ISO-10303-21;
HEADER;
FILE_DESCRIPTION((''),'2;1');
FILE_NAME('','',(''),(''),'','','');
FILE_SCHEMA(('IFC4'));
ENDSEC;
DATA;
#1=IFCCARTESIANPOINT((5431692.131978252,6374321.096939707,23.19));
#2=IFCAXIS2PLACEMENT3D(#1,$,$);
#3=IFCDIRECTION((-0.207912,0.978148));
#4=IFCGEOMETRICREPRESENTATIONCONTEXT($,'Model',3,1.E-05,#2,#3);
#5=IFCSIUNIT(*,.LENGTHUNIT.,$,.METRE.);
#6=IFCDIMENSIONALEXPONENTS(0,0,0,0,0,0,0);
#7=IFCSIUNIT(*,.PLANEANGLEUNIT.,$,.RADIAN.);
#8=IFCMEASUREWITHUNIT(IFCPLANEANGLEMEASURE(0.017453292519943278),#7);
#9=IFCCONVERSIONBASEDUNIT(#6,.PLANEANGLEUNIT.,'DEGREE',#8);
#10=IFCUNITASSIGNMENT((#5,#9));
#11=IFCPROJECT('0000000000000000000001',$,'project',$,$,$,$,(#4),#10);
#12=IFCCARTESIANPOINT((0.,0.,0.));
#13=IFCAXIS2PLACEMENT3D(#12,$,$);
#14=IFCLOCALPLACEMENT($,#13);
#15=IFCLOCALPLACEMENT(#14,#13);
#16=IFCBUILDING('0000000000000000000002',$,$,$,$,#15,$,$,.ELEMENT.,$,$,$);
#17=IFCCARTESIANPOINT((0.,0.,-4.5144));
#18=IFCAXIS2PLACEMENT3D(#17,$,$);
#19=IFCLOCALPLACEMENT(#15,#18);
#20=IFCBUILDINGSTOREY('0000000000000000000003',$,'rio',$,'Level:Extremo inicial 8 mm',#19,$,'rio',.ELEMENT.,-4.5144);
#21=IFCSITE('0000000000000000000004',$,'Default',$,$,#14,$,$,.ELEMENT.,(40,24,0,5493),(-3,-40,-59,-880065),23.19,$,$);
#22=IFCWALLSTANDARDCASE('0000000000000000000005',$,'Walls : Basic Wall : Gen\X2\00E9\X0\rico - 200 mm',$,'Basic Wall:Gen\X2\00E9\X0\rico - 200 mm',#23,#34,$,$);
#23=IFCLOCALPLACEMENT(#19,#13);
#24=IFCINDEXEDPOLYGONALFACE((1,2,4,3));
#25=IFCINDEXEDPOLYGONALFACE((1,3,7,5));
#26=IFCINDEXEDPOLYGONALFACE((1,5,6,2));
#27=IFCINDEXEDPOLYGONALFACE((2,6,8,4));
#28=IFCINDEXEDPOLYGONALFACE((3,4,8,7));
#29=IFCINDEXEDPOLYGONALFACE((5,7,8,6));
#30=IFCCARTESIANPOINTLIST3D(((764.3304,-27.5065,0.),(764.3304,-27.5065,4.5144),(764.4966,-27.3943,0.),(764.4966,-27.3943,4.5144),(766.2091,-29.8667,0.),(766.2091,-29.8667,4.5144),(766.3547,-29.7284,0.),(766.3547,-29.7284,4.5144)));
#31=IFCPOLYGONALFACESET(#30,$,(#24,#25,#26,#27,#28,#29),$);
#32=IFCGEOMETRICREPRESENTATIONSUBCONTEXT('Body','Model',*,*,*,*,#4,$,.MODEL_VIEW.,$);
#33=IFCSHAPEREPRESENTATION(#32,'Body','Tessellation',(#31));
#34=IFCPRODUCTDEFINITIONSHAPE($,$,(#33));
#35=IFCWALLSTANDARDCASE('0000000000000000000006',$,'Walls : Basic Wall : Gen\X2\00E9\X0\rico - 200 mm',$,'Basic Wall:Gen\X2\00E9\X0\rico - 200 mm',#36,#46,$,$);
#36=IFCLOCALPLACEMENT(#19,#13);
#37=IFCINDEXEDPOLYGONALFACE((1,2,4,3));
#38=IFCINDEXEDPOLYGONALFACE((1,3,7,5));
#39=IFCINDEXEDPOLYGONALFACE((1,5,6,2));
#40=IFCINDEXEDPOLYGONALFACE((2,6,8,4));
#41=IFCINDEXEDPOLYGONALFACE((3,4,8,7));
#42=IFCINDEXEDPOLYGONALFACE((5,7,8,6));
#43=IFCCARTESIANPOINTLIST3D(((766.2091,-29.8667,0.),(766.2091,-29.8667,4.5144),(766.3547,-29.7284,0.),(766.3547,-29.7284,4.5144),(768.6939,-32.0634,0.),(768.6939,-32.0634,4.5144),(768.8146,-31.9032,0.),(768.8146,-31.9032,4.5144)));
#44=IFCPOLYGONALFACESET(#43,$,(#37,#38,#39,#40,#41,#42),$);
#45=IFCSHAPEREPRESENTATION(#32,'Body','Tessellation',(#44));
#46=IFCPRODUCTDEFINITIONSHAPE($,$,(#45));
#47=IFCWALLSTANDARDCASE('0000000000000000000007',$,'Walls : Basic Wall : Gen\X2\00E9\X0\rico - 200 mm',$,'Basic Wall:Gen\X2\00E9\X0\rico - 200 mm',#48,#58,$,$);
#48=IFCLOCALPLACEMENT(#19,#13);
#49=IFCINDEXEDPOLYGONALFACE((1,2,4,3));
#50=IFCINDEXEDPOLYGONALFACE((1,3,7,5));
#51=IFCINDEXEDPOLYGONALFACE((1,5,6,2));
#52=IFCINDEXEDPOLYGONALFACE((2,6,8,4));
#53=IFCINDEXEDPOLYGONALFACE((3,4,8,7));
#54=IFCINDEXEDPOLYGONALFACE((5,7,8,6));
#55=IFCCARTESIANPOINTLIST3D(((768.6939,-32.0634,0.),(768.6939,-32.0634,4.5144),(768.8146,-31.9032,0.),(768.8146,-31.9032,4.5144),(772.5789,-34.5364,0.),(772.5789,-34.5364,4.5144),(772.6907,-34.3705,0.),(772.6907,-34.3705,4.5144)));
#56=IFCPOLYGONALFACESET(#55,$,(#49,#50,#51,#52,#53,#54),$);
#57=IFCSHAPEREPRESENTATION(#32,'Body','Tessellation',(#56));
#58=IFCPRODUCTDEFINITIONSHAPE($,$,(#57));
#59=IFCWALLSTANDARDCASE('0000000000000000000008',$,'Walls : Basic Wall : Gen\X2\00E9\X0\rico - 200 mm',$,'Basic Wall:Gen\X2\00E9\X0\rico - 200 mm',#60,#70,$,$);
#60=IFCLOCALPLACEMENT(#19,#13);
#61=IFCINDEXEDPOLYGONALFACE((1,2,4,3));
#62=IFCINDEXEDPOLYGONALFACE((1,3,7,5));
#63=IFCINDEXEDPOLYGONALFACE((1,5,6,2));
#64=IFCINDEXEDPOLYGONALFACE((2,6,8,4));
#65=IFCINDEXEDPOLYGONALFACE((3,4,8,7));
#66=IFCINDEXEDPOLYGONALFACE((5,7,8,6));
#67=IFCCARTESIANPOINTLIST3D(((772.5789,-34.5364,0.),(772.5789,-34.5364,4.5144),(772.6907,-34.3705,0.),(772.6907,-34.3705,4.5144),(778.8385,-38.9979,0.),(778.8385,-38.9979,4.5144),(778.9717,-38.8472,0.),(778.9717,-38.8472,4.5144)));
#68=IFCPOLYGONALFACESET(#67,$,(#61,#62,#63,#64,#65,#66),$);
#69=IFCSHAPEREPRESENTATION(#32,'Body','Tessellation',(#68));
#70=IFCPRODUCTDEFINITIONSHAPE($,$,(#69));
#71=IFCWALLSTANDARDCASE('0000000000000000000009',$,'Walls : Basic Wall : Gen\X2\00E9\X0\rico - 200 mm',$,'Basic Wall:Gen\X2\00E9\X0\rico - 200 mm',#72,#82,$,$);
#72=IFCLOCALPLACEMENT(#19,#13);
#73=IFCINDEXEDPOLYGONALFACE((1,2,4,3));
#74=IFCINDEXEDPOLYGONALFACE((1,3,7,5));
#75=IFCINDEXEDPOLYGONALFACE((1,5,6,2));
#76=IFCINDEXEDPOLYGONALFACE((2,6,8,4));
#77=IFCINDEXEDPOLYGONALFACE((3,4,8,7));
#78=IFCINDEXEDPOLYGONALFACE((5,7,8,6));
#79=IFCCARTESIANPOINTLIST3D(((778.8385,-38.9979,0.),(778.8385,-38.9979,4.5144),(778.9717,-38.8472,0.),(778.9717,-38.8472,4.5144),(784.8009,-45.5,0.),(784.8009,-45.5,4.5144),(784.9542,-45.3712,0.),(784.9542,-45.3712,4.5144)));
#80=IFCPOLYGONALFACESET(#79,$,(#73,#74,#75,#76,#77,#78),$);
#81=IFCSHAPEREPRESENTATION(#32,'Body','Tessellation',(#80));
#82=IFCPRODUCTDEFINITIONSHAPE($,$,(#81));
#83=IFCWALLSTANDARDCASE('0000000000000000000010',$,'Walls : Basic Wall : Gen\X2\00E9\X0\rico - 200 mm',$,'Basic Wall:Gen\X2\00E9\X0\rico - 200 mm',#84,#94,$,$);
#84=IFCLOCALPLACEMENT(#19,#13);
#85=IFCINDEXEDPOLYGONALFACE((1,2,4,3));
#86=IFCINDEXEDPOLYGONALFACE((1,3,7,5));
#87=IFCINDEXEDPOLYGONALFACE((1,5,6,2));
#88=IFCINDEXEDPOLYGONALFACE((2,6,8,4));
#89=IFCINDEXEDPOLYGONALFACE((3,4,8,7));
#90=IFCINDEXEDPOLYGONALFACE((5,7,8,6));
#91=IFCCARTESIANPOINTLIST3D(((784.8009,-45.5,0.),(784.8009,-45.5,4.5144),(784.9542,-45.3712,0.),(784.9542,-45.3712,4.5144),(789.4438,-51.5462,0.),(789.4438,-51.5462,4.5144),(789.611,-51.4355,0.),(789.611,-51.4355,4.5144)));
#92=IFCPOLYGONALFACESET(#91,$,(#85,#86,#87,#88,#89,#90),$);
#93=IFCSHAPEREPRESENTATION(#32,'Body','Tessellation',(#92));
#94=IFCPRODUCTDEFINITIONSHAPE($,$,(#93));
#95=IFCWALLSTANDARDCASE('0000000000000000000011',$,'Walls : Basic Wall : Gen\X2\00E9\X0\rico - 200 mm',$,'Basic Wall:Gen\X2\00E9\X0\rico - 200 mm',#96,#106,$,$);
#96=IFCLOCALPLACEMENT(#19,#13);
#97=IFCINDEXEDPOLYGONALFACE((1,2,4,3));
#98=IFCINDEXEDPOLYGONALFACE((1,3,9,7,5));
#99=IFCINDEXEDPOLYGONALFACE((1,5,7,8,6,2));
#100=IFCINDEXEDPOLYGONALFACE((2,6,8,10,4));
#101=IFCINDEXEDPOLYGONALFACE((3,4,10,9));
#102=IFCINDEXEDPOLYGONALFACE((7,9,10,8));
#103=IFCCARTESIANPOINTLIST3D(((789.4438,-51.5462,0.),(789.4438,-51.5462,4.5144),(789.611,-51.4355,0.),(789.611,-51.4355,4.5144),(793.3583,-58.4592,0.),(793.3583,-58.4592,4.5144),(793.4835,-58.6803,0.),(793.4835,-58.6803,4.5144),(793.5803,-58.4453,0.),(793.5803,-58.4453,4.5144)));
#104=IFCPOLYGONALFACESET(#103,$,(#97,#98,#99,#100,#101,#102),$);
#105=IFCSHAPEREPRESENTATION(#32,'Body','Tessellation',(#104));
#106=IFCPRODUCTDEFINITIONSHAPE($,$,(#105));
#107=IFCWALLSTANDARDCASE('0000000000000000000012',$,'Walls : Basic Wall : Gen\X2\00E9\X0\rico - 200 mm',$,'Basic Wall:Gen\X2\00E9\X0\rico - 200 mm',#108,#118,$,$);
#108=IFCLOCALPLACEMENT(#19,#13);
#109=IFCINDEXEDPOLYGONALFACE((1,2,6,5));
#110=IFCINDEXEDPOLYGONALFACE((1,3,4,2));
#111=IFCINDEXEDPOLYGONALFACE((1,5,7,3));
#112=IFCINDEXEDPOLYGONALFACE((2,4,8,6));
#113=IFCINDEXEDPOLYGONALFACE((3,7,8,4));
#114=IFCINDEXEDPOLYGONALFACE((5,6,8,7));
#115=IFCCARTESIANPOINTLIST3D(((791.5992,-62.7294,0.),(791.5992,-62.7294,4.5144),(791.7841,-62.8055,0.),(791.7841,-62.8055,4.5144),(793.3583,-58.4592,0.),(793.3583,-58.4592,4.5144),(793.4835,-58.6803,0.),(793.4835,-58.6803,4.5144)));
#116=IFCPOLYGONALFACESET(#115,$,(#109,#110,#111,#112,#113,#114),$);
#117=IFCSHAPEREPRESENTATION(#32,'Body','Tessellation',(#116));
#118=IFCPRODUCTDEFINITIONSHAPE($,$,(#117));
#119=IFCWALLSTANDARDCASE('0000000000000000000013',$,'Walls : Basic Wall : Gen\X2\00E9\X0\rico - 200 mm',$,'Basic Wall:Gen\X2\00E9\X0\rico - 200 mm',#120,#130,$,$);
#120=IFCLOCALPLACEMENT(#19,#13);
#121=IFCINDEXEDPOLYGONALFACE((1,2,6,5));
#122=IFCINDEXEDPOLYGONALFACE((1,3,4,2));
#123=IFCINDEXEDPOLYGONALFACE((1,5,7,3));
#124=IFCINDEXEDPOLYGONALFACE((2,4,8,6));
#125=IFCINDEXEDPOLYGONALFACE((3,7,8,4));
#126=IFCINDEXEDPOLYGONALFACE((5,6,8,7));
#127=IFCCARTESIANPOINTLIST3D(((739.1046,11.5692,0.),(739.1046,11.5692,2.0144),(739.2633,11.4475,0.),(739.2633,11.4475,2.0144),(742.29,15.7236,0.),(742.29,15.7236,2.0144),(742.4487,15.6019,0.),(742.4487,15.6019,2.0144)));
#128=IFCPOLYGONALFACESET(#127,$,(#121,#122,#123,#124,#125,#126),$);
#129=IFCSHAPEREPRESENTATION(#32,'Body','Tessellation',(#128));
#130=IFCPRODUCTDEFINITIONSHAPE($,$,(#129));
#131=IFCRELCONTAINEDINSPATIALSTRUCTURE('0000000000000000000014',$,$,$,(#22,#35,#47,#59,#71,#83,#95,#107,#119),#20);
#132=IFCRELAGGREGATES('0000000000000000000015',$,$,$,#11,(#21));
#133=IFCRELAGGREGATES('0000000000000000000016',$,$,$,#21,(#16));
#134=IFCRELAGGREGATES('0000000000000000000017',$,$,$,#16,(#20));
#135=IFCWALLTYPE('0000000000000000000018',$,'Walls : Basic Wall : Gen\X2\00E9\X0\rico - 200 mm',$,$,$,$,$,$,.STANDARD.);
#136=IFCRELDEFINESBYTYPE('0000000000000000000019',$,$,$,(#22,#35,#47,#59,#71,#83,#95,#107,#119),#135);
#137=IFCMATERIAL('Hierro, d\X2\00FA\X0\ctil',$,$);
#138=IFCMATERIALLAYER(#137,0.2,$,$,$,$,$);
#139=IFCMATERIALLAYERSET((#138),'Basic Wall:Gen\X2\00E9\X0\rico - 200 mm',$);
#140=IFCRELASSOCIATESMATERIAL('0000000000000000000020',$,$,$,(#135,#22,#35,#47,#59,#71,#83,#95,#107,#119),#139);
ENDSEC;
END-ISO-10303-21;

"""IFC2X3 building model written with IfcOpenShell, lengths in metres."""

from ifc_helpers import new_model, entity, si_unit, converted_unit, direction, frame, frame_2d, origin, place, context, subcontext, project, spatial, polyline, rectangle, outline, extrude, clip, bounded_halfspace, material, layer, layer_set, layer_usage, type_object, element, save


model = new_model("IFC2X3")

# Units and contexts
model_context = context("Model", 3, precision=1e-05, world=frame((5431692.131978252, 6374321.096939707, 23.19)), true_north=direction((-0.207912, 0.978148)))
body_context = subcontext(model_context, "Body", "Model", "MODEL_VIEW")
ifc_project = project(units=[si_unit("LENGTHUNIT", "METRE"), converted_unit("PLANEANGLEUNIT", "DEGREE", entity("IfcPlaneAngleMeasure", 0.017453292519943278), si_unit("PLANEANGLEUNIT", "RADIAN"), dimensions=[0, 0, 0, 0, 0, 0, 0])], contexts=[model_context])

# Site, building, storey
site_placement = place(None, origin())
site = spatial("IfcSite", under=ifc_project, at=site_placement, Name="Default", CompositionType="ELEMENT", RefLatitude=(40, 24, 0, 5493), RefLongitude=(-3, -40, -59, -880065), RefElevation=23.19)
building_placement = place(site_placement, origin())
building = spatial("IfcBuilding", under=site, at=building_placement, CompositionType="ELEMENT")
storey_placement = place(building_placement, frame((0.0, 0.0, -4.5144)))
storey = spatial("IfcBuildingStorey", under=building, at=storey_placement, Name="rio", ObjectType="Level:Extremo inicial 8 mm", LongName="rio", CompositionType="ELEMENT", Elevation=-4.5144)

# Walls
ifc_material = material(Name="Hierro, dúctil")
ifc_layer = layer(ifc_material, 0.2)
ifc_layer_set = layer_set([ifc_layer], Name="Basic Wall:Genérico - 200 mm")
wall_type = type_object("IfcWallType", Name="Walls : Basic Wall : Genérico - 200 mm", PredefinedType="STANDARD", material=ifc_layer_set)
ifc_layer_usage_1 = layer_usage(ifc_layer_set, "AXIS2", "NEGATIVE", 0.1)
wall_1_placement = place(storey_placement, frame((764.4086, -27.4443, 0.0), z_axis=(0.0, 0.0, 1.0), x_axis=(0.6228, -0.782381, 0.0)))
element("IfcWallStandardCase", 1, at=wall_1_placement, inside=storey, type_object=wall_type, material=ifc_layer_usage_1, Name="Walls : Basic Wall : Genérico - 200 mm", ObjectType="Basic Wall:Genérico - 200 mm", context=body_context, shape_type="SweptSolid", body=[
    extrude(outline(polyline([(3.0166, -0.1), (2.9991, 0.1), (0.0157, 0.1), (0.0, -0.1), (3.0166, -0.1)])), origin(), (0.0, 0.0, 1.0), 4.5144),
])
ifc_layer_usage_2 = layer_usage(ifc_layer_set, "AXIS2", "NEGATIVE", 0.1)
wall_2_placement = place(storey_placement, frame((766.2754, -29.7918, 0.0), z_axis=(0.0, 0.0, 1.0), x_axis=(0.749198, -0.662347, 0.0)))
element("IfcWallStandardCase", 2, at=wall_2_placement, inside=storey, type_object=wall_type, material=ifc_layer_usage_2, Name="Walls : Basic Wall : Genérico - 200 mm", ObjectType="Basic Wall:Genérico - 200 mm", context=body_context, shape_type="SweptSolid", body=[
    extrude(outline(polyline([(3.3166, -0.1), (3.3009, 0.1), (0.0175, 0.1), (0.0, -0.1), (3.3166, -0.1)])), origin(), (0.0, 0.0, 1.0), 4.5144),
])
ifc_layer_usage_3 = layer_usage(ifc_layer_set, "AXIS2", "NEGATIVE", 0.1)
wall_3_placement = place(storey_placement, frame((768.7476, -31.9791, 0.0), z_axis=(0.0, 0.0, 1.0), x_axis=(0.843588, -0.536992, 0.0)))
element("IfcWallStandardCase", 3, at=wall_3_placement, inside=storey, type_object=wall_type, material=ifc_layer_usage_3, Name="Walls : Basic Wall : Genérico - 200 mm", ObjectType="Basic Wall:Genérico - 200 mm", context=body_context, shape_type="SweptSolid", body=[
    extrude(outline(polyline([(4.6053, -0.1), (4.6105, 0.1), (0.0157, 0.1), (0.0, -0.1), (4.6053, -0.1)])), origin(), (0.0, 0.0, 1.0), 4.5144),
])
ifc_layer_usage_4 = layer_usage(ifc_layer_set, "AXIS2", "NEGATIVE", 0.1)
wall_4_placement = place(storey_placement, frame((772.6326, -34.4519, 0.0), z_axis=(0.0, 0.0, 1.0), x_axis=(0.814328, -0.580406, 0.0)))
element("IfcWallStandardCase", 4, at=wall_4_placement, inside=storey, type_object=wall_type, material=ifc_layer_usage_4, Name="Walls : Basic Wall : Genérico - 200 mm", ObjectType="Basic Wall:Genérico - 200 mm", context=body_context, shape_type="SweptSolid", body=[
    extrude(outline(polyline([(7.6921, -0.1), (7.7131, 0.1), (0.0, 0.1), (0.0052, -0.1), (7.6921, -0.1)])), origin(), (0.0, 0.0, 1.0), 4.5144),
])
ifc_layer_usage_5 = layer_usage(ifc_layer_set, "AXIS2", "NEGATIVE", 0.1)
wall_5_placement = place(storey_placement, frame((778.898, -38.9148, 0.0), z_axis=(0.0, 0.0, 1.0), x_axis=(0.675859, -0.737031, 0.0)))
element("IfcWallStandardCase", 5, at=wall_5_placement, inside=storey, type_object=wall_type, material=ifc_layer_usage_5, Name="Walls : Basic Wall : Genérico - 200 mm", ObjectType="Basic Wall:Genérico - 200 mm", context=body_context, shape_type="SweptSolid", body=[
    extrude(outline(polyline([(8.843, -0.1), (8.8517, 0.1), (0.0, 0.1), (0.021, -0.1), (8.843, -0.1)])), origin(), (0.0, 0.0, 1.0), 4.5144),
])
ifc_layer_usage_6 = layer_usage(ifc_layer_set, "AXIS2", "NEGATIVE", 0.1)
wall_6_placement = place(storey_placement, frame((784.8749, -45.4321, 0.0), z_axis=(0.0, 0.0, 1.0), x_axis=(0.609051, -0.793131, 0.0)))
element("IfcWallStandardCase", 6, at=wall_6_placement, inside=storey, type_object=wall_type, material=ifc_layer_usage_6, Name="Walls : Basic Wall : Genérico - 200 mm", ObjectType="Basic Wall:Genérico - 200 mm", context=body_context, shape_type="SweptSolid", body=[
    extrude(outline(polyline([(7.632, -0.1), (7.6459, 0.1), (0.0, 0.1), (0.0087, -0.1), (7.632, -0.1)])), origin(), (0.0, 0.0, 1.0), 4.5144),
])
ifc_layer_usage_7 = layer_usage(ifc_layer_set, "AXIS2", "NEGATIVE", 0.1)
wall_7_placement = place(storey_placement, frame((789.524, -51.4848, 0.0), z_axis=(0.0, 0.0, 1.0), x_axis=(0.492741, -0.870176, 0.0)))
element("IfcWallStandardCase", 7, at=wall_7_placement, inside=storey, type_object=wall_type, material=ifc_layer_usage_7, Name="Walls : Basic Wall : Genérico - 200 mm", ObjectType="Basic Wall:Genérico - 200 mm", context=body_context, shape_type="SweptSolid", body=[
    extrude(outline(polyline([(8.2124, -0.1), (8.0557, 0.1), (0.0, 0.1), (0.014, -0.1), (7.9583, -0.1), (8.2124, -0.1)])), origin(), (0.0, 0.0, 1.0), 4.5144),
])
ifc_layer_usage_8 = layer_usage(ifc_layer_set, "AXIS2", "NEGATIVE", 0.1)
wall_8_placement = place(storey_placement, frame((793.4508, -58.4973, 0.0), z_axis=(0.0, 0.0, 1.0), x_axis=(-0.380899, -0.924616, 0.0)))
element("IfcWallStandardCase", 8, at=wall_8_placement, inside=storey, type_object=wall_type, material=ifc_layer_usage_8, Name="Walls : Basic Wall : Genérico - 200 mm", ObjectType="Basic Wall:Genérico - 200 mm", context=body_context, shape_type="SweptSolid", body=[
    extrude(outline(polyline([(4.6184, -0.1), (4.6184, 0.1), (0.1568, 0.1), (0.0, -0.1), (4.6184, -0.1)])), origin(), (0.0, 0.0, 1.0), 4.5144),
])
ifc_layer_usage_9 = layer_usage(ifc_layer_set, "AXIS2", "NEGATIVE", 0.1)
wall_9_placement = place(storey_placement, frame((742.3693, 15.6627, 0.0), z_axis=(0.0, 0.0, 1.0), x_axis=(-0.608472, -0.793576, 0.0)))
element("IfcWallStandardCase", 9, at=wall_9_placement, inside=storey, type_object=wall_type, material=ifc_layer_usage_9, Name="Walls : Basic Wall : Genérico - 200 mm", ObjectType="Basic Wall:Genérico - 200 mm", context=body_context, shape_type="Clipping", body=[
    clip(extrude(rectangle(XDim=5.2351, YDim=0.2, at=frame_2d((2.6175, 0.0), x_axis=(-1.0, 0.0))), origin(), (0.0, 0.0, 1.0), 2.0144), bounded_halfspace(frame((0.0, -0.1, 2.0144), z_axis=(0.0, 0.0, 1.0), x_axis=(-0.608472, 0.793576, 0.0)), False, frame((0.0, -0.1, 2.0144)), polyline([(0.0, 0.0), (5.2351, 0.0), (5.2351, 0.2), (0.0, 0.2), (0.0, 0.0)]))),
])

save(model, "model.ifc")
